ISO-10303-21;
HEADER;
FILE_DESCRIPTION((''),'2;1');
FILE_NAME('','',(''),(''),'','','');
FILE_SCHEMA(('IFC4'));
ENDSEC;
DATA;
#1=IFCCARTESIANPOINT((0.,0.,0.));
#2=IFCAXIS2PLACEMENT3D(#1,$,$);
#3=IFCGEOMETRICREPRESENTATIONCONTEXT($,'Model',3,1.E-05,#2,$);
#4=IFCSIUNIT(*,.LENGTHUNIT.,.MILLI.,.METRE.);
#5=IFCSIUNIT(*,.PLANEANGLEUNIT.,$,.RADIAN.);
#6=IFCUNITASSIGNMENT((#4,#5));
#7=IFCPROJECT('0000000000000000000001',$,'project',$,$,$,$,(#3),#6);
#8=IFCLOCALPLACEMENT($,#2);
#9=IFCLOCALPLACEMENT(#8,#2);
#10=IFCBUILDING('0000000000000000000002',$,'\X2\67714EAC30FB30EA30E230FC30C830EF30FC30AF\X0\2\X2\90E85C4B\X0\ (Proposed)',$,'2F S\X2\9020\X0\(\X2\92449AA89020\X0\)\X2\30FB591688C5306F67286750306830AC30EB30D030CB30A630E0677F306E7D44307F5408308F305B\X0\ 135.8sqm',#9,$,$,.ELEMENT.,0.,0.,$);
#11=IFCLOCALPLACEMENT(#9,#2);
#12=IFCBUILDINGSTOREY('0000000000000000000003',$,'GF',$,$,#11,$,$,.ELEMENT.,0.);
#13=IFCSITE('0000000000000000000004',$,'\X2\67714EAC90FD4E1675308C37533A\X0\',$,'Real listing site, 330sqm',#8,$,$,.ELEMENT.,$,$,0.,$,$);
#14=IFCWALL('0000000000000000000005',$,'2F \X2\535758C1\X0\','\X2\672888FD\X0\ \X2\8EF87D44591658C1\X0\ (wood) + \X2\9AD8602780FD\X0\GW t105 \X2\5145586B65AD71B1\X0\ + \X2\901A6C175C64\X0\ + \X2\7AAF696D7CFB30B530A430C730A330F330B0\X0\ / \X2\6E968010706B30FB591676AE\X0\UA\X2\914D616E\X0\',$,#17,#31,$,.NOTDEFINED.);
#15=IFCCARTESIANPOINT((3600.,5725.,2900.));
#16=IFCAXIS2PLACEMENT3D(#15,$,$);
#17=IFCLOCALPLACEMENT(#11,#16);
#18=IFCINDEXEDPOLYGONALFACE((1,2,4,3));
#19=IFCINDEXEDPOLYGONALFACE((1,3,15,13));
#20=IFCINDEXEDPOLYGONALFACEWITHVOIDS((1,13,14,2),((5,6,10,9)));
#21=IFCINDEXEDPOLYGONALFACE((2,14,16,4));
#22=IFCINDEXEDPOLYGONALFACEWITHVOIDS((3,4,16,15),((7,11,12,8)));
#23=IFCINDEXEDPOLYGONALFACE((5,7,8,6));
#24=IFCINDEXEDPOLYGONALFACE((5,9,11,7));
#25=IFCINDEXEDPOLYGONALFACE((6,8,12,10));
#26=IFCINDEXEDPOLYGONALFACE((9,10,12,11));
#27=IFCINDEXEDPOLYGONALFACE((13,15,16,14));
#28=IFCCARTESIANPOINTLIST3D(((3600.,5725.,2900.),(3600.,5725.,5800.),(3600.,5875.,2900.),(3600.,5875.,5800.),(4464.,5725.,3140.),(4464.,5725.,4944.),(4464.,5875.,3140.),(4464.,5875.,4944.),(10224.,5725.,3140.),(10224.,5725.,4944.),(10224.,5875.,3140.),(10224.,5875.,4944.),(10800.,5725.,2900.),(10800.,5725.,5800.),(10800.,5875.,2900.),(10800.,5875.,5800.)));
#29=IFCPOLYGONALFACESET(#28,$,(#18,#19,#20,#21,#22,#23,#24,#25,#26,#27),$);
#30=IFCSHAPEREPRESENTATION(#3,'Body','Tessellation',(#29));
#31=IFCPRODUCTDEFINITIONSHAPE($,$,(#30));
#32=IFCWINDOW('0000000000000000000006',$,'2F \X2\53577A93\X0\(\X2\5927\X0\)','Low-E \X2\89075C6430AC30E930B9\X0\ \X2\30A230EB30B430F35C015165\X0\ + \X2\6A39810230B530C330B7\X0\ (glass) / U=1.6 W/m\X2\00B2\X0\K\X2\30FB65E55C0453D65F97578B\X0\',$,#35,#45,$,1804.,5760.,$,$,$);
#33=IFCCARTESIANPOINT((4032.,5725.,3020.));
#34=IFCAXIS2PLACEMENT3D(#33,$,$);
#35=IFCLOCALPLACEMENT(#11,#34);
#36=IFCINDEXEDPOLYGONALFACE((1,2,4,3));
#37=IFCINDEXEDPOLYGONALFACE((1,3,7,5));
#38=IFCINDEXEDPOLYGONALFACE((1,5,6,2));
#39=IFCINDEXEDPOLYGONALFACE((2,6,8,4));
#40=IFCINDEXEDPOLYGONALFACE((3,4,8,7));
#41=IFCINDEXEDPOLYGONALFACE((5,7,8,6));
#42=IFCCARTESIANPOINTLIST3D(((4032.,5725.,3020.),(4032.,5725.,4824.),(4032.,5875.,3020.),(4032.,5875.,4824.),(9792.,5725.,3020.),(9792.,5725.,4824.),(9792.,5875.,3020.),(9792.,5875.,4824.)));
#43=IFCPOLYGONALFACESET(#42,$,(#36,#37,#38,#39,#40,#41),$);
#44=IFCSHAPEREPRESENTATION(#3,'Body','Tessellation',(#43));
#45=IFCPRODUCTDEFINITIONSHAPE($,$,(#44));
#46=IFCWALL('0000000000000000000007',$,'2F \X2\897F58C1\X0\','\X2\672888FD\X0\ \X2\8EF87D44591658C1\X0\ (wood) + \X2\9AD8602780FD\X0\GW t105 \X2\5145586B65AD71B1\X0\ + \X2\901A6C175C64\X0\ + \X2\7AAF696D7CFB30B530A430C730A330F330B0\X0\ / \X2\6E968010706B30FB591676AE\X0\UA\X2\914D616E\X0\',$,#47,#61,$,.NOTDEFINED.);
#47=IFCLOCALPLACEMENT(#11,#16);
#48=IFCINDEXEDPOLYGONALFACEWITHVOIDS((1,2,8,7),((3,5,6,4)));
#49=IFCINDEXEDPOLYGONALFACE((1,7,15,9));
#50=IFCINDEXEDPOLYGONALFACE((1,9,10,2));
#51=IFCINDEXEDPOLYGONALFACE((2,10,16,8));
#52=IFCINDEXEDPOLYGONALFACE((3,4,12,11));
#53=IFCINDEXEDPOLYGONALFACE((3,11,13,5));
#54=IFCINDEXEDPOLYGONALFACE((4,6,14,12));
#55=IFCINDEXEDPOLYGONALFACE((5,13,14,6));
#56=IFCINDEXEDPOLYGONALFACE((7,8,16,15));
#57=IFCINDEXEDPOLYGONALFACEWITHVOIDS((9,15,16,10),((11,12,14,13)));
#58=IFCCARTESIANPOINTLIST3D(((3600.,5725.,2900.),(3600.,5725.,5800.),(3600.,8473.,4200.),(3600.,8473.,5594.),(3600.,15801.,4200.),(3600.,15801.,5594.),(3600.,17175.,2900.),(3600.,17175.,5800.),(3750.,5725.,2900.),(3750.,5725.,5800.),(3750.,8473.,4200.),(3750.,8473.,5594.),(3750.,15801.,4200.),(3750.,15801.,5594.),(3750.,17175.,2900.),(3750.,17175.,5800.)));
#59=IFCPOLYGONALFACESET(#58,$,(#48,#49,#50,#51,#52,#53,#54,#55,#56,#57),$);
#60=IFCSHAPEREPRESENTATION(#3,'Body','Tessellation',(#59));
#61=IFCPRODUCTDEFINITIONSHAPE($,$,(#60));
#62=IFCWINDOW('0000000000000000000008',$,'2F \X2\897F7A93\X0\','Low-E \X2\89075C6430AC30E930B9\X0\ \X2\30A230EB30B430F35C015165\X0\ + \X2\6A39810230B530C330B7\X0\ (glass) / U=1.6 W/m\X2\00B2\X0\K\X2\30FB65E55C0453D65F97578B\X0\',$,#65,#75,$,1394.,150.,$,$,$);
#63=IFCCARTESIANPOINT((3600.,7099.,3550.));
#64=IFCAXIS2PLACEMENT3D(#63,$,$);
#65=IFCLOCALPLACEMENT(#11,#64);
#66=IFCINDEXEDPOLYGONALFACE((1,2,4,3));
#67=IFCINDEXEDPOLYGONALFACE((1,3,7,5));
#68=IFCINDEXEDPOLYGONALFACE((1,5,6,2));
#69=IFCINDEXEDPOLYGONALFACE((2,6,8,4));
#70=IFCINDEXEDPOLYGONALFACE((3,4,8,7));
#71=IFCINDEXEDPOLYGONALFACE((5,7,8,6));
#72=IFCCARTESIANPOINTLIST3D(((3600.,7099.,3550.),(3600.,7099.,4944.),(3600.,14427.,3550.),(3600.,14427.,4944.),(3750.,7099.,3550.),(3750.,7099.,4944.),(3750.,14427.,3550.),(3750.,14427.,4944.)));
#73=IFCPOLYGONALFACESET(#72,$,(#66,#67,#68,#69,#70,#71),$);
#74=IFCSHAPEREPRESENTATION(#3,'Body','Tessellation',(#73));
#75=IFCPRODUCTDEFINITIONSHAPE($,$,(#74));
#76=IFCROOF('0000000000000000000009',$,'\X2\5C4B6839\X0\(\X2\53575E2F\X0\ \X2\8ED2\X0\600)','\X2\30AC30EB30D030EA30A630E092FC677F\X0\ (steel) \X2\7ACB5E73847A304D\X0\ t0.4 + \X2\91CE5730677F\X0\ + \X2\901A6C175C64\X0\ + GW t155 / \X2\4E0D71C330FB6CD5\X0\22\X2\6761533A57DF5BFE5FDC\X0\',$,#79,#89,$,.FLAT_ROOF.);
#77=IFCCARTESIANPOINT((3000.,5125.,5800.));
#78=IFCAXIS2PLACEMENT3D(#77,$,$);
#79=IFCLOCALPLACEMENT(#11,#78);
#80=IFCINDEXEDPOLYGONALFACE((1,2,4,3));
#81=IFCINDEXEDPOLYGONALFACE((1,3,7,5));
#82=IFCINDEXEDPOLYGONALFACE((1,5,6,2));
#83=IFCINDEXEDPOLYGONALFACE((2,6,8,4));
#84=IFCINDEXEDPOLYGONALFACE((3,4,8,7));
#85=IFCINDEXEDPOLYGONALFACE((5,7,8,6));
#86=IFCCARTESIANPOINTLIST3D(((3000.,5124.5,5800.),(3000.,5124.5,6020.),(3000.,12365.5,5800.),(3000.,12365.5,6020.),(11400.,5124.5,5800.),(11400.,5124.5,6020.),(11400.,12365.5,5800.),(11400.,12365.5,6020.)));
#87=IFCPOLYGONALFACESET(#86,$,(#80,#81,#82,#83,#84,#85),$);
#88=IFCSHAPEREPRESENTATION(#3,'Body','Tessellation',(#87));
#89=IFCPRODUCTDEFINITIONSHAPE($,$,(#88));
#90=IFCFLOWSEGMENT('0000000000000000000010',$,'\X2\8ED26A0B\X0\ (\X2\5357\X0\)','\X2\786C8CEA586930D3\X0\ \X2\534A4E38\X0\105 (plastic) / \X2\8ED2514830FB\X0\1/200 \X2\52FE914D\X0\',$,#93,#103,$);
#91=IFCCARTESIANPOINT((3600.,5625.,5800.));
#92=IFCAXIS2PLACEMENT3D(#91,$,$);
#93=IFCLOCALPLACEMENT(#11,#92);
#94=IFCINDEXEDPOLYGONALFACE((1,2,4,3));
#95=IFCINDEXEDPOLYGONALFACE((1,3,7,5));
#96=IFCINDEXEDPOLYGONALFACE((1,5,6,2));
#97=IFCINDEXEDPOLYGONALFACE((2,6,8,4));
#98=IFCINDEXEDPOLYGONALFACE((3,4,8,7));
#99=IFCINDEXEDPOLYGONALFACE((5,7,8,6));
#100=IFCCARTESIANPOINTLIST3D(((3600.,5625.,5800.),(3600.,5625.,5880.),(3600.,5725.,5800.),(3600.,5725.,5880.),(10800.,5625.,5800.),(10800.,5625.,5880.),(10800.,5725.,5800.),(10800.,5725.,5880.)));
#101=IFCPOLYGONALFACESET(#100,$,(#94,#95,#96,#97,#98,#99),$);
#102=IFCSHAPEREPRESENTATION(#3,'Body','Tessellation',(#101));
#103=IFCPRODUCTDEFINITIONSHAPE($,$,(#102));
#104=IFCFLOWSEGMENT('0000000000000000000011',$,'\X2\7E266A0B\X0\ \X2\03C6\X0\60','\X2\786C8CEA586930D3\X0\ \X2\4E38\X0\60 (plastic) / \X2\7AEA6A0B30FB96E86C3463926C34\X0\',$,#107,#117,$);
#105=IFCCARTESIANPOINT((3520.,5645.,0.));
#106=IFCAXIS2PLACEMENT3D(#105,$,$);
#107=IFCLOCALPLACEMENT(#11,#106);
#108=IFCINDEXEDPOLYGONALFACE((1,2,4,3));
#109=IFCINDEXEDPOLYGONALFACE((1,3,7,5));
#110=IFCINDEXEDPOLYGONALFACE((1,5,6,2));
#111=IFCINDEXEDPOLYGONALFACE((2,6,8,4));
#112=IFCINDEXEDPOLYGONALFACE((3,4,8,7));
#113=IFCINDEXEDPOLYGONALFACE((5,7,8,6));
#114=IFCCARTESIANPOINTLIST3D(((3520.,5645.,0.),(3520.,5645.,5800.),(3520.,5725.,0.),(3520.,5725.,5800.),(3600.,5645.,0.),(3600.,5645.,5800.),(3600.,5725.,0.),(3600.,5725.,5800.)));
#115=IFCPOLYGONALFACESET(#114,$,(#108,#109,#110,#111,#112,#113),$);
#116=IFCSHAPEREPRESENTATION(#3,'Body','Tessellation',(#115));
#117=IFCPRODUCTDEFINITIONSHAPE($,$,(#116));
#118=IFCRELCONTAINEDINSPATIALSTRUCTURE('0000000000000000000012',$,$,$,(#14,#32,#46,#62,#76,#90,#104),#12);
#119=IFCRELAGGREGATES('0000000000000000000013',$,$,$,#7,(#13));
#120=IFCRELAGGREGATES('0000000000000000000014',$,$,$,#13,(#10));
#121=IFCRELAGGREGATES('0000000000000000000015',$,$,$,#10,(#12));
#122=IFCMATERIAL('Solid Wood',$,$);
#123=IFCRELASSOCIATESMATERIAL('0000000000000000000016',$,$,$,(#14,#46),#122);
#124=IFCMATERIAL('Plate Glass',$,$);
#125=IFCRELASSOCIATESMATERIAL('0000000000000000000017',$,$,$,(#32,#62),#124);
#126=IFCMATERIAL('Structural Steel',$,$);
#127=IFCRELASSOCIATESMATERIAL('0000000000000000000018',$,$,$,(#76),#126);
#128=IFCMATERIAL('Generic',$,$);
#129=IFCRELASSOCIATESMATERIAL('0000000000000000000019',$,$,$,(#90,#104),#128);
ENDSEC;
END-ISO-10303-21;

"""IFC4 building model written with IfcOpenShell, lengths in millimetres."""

from ifc_helpers import new_model, si_unit, frame, frame_2d, origin, place, context, project, spatial, rectangle, extrude, material, element, fill, save


model = new_model("IFC4")

# Units and contexts
model_context = context("Model", 3, precision=1e-05, world=origin())
ifc_project = project(units=[si_unit("LENGTHUNIT", "METRE", prefix="MILLI"), si_unit("PLANEANGLEUNIT", "RADIAN")], contexts=[model_context])

# Site, building, storey
site_placement = place(None, origin())
site = spatial("IfcSite", under=ifc_project, at=site_placement, Name="東京都世田谷区", ObjectType="Real listing site, 330sqm", CompositionType="ELEMENT", RefElevation=0.0)
building_placement = place(site_placement, origin())
building = spatial("IfcBuilding", under=site, at=building_placement, Name="東京・リモートワーク2部屋 (Proposed)", ObjectType="2F S造(鉄骨造)・外装は木材とガルバニウム板の組み合わせ 135.8sqm", CompositionType="ELEMENT", ElevationOfRefHeight=0.0, ElevationOfTerrain=0.0)
storey_placement = place(building_placement, origin())
storey = spatial("IfcBuildingStorey", under=building, at=storey_placement, Name="GF", CompositionType="ELEMENT", Elevation=0.0)

# Shared definitions
ifc_material_1 = material(Name="Solid Wood")

# Shared definitions
ifc_material_2 = material(Name="Plate Glass")

# Walls, openings, windows
wall_1_placement = place(storey_placement, frame((3600.0, 5725.0, 2900.0)))
wall_1 = element("IfcWall", 1, at=wall_1_placement, inside=storey, material=ifc_material_1, Name="2F 南壁", Description="木製 軸組外壁 (wood) + 高性能GW t105 充填断熱 + 通気層 + 窯業系サイディング / 準耐火・外皮UA配慮", PredefinedType="NOTDEFINED", context=model_context, shape_type="SweptSolid", body=[
    extrude(rectangle(XDim=7200.0, YDim=150.0, at=frame_2d((3600.0, 75.0))), frame((3600.0, 5725.0, 2900.0)), (0.0, 0.0, 1.0), 2900.0),
])
opening_1_placement = place(storey_placement, frame((4032.0, 5725.0, 3020.0)))
opening_1 = element("IfcOpeningElement", 2, at=opening_1_placement, cuts=wall_1, PredefinedType="NOTDEFINED", context=model_context, shape_type="SweptSolid", body=[
    extrude(rectangle(XDim=5760.0, YDim=150.0, at=frame_2d((2880.0, 75.0))), frame((4032.0, 5725.0, 3020.0)), (0.0, 0.0, 1.0), 1804.0),
])
window_1_placement = place(storey_placement, frame((4032.0, 5725.0, 3020.0)))
window_1 = element("IfcWindow", 3, at=window_1_placement, inside=storey, material=ifc_material_2, Name="2F 南窓(大)", Description="Low-E 複層ガラス アルゴン封入 + 樹脂サッシ (glass) / U=1.6 W/m²K・日射取得型", OverallHeight=1804.0, OverallWidth=5760.0, context=model_context, shape_type="SweptSolid", body=[
    extrude(rectangle(XDim=5760.0, YDim=150.0, at=frame_2d((2880.0, 75.0))), frame((4032.0, 5725.0, 3020.0)), (0.0, 0.0, 1.0), 1804.0),
])
fill(opening_1, window_1)
wall_2_placement = place(storey_placement, frame((3600.0, 5725.0, 2900.0)))
wall_2 = element("IfcWall", 4, at=wall_2_placement, inside=storey, material=ifc_material_1, Name="2F 西壁", Description="木製 軸組外壁 (wood) + 高性能GW t105 充填断熱 + 通気層 + 窯業系サイディング / 準耐火・外皮UA配慮", PredefinedType="NOTDEFINED", context=model_context, shape_type="SweptSolid", body=[
    extrude(rectangle(XDim=150.0, YDim=11450.0, at=frame_2d((75.0, 5725.0))), frame((3600.0, 5725.0, 2900.0)), (0.0, 0.0, 1.0), 2900.0),
])
opening_2_placement = place(storey_placement, frame((3600.0, 7099.0, 3550.0)))
opening_2 = element("IfcOpeningElement", 5, at=opening_2_placement, cuts=wall_2, PredefinedType="NOTDEFINED", context=model_context, shape_type="SweptSolid", body=[
    extrude(rectangle(XDim=150.0, YDim=7328.0, at=frame_2d((75.0, 3664.0))), frame((3600.0, 7099.0, 3550.0)), (0.0, 0.0, 1.0), 1394.0),
])
window_2_placement = place(storey_placement, frame((3600.0, 7099.0, 3550.0)))
window_2 = element("IfcWindow", 6, at=window_2_placement, inside=storey, material=ifc_material_2, Name="2F 西窓", Description="Low-E 複層ガラス アルゴン封入 + 樹脂サッシ (glass) / U=1.6 W/m²K・日射取得型", OverallHeight=1394.0, OverallWidth=150.0, context=model_context, shape_type="SweptSolid", body=[
    extrude(rectangle(XDim=150.0, YDim=7328.0, at=frame_2d((75.0, 3664.0))), frame((3600.0, 7099.0, 3550.0)), (0.0, 0.0, 1.0), 1394.0),
])
fill(opening_2, window_2)

# Roof
ifc_material_3 = material(Name="Structural Steel")
for number, where, name in (
    (7, (3000.0, 5125.0, 5800.0), "屋根(南帯 軒600)"),
):
    element("IfcRoof", number, at=place(storey_placement, frame(where)), inside=storey, material=ifc_material_3, Name=name, Description="ガルバリウム鋼板 (steel) 立平葺き t0.4 + 野地板 + 通気層 + GW t155 / 不燃・法22条区域対応", PredefinedType="FLAT_ROOF", context=model_context, shape_type="SweptSolid", body=[
        extrude(rectangle(XDim=8400.0, YDim=7241.0, at=frame_2d((4200.0, 3620.0))), frame((3000.0, 5125.0, 5800.0)), (0.0, 0.0, 1.0), 220.0),
    ])

# Flow segments
ifc_material_4 = material(Name="Generic")
flow_segment_1_placement = place(storey_placement, frame((3600.0, 5625.0, 5800.0)))
element("IfcFlowSegment", 8, at=flow_segment_1_placement, inside=storey, material=ifc_material_4, Name="軒樋 (南)", Description="硬質塩ビ 半丸105 (plastic) / 軒先・1/200 勾配", context=model_context, shape_type="SweptSolid", body=[
    extrude(rectangle(XDim=7200.0, YDim=100.0, at=frame_2d((3600.0, 50.0))), frame((3600.0, 5625.0, 5800.0)), (0.0, 0.0, 1.0), 80.0),
])
flow_segment_2_placement = place(storey_placement, frame((3520.0, 5645.0, 0.0)))
element("IfcFlowSegment", 9, at=flow_segment_2_placement, inside=storey, material=ifc_material_4, Name="縦樋 φ60", Description="硬質塩ビ 丸60 (plastic) / 竪樋・雨水排水", context=model_context, shape_type="SweptSolid", body=[
    extrude(rectangle(XDim=80.0, YDim=80.0, at=frame_2d((40.0, 40.0))), frame((3520.0, 5645.0, 0.0)), (0.0, 0.0, 1.0), 5800.0),
])

save(model, "model.ifc")
